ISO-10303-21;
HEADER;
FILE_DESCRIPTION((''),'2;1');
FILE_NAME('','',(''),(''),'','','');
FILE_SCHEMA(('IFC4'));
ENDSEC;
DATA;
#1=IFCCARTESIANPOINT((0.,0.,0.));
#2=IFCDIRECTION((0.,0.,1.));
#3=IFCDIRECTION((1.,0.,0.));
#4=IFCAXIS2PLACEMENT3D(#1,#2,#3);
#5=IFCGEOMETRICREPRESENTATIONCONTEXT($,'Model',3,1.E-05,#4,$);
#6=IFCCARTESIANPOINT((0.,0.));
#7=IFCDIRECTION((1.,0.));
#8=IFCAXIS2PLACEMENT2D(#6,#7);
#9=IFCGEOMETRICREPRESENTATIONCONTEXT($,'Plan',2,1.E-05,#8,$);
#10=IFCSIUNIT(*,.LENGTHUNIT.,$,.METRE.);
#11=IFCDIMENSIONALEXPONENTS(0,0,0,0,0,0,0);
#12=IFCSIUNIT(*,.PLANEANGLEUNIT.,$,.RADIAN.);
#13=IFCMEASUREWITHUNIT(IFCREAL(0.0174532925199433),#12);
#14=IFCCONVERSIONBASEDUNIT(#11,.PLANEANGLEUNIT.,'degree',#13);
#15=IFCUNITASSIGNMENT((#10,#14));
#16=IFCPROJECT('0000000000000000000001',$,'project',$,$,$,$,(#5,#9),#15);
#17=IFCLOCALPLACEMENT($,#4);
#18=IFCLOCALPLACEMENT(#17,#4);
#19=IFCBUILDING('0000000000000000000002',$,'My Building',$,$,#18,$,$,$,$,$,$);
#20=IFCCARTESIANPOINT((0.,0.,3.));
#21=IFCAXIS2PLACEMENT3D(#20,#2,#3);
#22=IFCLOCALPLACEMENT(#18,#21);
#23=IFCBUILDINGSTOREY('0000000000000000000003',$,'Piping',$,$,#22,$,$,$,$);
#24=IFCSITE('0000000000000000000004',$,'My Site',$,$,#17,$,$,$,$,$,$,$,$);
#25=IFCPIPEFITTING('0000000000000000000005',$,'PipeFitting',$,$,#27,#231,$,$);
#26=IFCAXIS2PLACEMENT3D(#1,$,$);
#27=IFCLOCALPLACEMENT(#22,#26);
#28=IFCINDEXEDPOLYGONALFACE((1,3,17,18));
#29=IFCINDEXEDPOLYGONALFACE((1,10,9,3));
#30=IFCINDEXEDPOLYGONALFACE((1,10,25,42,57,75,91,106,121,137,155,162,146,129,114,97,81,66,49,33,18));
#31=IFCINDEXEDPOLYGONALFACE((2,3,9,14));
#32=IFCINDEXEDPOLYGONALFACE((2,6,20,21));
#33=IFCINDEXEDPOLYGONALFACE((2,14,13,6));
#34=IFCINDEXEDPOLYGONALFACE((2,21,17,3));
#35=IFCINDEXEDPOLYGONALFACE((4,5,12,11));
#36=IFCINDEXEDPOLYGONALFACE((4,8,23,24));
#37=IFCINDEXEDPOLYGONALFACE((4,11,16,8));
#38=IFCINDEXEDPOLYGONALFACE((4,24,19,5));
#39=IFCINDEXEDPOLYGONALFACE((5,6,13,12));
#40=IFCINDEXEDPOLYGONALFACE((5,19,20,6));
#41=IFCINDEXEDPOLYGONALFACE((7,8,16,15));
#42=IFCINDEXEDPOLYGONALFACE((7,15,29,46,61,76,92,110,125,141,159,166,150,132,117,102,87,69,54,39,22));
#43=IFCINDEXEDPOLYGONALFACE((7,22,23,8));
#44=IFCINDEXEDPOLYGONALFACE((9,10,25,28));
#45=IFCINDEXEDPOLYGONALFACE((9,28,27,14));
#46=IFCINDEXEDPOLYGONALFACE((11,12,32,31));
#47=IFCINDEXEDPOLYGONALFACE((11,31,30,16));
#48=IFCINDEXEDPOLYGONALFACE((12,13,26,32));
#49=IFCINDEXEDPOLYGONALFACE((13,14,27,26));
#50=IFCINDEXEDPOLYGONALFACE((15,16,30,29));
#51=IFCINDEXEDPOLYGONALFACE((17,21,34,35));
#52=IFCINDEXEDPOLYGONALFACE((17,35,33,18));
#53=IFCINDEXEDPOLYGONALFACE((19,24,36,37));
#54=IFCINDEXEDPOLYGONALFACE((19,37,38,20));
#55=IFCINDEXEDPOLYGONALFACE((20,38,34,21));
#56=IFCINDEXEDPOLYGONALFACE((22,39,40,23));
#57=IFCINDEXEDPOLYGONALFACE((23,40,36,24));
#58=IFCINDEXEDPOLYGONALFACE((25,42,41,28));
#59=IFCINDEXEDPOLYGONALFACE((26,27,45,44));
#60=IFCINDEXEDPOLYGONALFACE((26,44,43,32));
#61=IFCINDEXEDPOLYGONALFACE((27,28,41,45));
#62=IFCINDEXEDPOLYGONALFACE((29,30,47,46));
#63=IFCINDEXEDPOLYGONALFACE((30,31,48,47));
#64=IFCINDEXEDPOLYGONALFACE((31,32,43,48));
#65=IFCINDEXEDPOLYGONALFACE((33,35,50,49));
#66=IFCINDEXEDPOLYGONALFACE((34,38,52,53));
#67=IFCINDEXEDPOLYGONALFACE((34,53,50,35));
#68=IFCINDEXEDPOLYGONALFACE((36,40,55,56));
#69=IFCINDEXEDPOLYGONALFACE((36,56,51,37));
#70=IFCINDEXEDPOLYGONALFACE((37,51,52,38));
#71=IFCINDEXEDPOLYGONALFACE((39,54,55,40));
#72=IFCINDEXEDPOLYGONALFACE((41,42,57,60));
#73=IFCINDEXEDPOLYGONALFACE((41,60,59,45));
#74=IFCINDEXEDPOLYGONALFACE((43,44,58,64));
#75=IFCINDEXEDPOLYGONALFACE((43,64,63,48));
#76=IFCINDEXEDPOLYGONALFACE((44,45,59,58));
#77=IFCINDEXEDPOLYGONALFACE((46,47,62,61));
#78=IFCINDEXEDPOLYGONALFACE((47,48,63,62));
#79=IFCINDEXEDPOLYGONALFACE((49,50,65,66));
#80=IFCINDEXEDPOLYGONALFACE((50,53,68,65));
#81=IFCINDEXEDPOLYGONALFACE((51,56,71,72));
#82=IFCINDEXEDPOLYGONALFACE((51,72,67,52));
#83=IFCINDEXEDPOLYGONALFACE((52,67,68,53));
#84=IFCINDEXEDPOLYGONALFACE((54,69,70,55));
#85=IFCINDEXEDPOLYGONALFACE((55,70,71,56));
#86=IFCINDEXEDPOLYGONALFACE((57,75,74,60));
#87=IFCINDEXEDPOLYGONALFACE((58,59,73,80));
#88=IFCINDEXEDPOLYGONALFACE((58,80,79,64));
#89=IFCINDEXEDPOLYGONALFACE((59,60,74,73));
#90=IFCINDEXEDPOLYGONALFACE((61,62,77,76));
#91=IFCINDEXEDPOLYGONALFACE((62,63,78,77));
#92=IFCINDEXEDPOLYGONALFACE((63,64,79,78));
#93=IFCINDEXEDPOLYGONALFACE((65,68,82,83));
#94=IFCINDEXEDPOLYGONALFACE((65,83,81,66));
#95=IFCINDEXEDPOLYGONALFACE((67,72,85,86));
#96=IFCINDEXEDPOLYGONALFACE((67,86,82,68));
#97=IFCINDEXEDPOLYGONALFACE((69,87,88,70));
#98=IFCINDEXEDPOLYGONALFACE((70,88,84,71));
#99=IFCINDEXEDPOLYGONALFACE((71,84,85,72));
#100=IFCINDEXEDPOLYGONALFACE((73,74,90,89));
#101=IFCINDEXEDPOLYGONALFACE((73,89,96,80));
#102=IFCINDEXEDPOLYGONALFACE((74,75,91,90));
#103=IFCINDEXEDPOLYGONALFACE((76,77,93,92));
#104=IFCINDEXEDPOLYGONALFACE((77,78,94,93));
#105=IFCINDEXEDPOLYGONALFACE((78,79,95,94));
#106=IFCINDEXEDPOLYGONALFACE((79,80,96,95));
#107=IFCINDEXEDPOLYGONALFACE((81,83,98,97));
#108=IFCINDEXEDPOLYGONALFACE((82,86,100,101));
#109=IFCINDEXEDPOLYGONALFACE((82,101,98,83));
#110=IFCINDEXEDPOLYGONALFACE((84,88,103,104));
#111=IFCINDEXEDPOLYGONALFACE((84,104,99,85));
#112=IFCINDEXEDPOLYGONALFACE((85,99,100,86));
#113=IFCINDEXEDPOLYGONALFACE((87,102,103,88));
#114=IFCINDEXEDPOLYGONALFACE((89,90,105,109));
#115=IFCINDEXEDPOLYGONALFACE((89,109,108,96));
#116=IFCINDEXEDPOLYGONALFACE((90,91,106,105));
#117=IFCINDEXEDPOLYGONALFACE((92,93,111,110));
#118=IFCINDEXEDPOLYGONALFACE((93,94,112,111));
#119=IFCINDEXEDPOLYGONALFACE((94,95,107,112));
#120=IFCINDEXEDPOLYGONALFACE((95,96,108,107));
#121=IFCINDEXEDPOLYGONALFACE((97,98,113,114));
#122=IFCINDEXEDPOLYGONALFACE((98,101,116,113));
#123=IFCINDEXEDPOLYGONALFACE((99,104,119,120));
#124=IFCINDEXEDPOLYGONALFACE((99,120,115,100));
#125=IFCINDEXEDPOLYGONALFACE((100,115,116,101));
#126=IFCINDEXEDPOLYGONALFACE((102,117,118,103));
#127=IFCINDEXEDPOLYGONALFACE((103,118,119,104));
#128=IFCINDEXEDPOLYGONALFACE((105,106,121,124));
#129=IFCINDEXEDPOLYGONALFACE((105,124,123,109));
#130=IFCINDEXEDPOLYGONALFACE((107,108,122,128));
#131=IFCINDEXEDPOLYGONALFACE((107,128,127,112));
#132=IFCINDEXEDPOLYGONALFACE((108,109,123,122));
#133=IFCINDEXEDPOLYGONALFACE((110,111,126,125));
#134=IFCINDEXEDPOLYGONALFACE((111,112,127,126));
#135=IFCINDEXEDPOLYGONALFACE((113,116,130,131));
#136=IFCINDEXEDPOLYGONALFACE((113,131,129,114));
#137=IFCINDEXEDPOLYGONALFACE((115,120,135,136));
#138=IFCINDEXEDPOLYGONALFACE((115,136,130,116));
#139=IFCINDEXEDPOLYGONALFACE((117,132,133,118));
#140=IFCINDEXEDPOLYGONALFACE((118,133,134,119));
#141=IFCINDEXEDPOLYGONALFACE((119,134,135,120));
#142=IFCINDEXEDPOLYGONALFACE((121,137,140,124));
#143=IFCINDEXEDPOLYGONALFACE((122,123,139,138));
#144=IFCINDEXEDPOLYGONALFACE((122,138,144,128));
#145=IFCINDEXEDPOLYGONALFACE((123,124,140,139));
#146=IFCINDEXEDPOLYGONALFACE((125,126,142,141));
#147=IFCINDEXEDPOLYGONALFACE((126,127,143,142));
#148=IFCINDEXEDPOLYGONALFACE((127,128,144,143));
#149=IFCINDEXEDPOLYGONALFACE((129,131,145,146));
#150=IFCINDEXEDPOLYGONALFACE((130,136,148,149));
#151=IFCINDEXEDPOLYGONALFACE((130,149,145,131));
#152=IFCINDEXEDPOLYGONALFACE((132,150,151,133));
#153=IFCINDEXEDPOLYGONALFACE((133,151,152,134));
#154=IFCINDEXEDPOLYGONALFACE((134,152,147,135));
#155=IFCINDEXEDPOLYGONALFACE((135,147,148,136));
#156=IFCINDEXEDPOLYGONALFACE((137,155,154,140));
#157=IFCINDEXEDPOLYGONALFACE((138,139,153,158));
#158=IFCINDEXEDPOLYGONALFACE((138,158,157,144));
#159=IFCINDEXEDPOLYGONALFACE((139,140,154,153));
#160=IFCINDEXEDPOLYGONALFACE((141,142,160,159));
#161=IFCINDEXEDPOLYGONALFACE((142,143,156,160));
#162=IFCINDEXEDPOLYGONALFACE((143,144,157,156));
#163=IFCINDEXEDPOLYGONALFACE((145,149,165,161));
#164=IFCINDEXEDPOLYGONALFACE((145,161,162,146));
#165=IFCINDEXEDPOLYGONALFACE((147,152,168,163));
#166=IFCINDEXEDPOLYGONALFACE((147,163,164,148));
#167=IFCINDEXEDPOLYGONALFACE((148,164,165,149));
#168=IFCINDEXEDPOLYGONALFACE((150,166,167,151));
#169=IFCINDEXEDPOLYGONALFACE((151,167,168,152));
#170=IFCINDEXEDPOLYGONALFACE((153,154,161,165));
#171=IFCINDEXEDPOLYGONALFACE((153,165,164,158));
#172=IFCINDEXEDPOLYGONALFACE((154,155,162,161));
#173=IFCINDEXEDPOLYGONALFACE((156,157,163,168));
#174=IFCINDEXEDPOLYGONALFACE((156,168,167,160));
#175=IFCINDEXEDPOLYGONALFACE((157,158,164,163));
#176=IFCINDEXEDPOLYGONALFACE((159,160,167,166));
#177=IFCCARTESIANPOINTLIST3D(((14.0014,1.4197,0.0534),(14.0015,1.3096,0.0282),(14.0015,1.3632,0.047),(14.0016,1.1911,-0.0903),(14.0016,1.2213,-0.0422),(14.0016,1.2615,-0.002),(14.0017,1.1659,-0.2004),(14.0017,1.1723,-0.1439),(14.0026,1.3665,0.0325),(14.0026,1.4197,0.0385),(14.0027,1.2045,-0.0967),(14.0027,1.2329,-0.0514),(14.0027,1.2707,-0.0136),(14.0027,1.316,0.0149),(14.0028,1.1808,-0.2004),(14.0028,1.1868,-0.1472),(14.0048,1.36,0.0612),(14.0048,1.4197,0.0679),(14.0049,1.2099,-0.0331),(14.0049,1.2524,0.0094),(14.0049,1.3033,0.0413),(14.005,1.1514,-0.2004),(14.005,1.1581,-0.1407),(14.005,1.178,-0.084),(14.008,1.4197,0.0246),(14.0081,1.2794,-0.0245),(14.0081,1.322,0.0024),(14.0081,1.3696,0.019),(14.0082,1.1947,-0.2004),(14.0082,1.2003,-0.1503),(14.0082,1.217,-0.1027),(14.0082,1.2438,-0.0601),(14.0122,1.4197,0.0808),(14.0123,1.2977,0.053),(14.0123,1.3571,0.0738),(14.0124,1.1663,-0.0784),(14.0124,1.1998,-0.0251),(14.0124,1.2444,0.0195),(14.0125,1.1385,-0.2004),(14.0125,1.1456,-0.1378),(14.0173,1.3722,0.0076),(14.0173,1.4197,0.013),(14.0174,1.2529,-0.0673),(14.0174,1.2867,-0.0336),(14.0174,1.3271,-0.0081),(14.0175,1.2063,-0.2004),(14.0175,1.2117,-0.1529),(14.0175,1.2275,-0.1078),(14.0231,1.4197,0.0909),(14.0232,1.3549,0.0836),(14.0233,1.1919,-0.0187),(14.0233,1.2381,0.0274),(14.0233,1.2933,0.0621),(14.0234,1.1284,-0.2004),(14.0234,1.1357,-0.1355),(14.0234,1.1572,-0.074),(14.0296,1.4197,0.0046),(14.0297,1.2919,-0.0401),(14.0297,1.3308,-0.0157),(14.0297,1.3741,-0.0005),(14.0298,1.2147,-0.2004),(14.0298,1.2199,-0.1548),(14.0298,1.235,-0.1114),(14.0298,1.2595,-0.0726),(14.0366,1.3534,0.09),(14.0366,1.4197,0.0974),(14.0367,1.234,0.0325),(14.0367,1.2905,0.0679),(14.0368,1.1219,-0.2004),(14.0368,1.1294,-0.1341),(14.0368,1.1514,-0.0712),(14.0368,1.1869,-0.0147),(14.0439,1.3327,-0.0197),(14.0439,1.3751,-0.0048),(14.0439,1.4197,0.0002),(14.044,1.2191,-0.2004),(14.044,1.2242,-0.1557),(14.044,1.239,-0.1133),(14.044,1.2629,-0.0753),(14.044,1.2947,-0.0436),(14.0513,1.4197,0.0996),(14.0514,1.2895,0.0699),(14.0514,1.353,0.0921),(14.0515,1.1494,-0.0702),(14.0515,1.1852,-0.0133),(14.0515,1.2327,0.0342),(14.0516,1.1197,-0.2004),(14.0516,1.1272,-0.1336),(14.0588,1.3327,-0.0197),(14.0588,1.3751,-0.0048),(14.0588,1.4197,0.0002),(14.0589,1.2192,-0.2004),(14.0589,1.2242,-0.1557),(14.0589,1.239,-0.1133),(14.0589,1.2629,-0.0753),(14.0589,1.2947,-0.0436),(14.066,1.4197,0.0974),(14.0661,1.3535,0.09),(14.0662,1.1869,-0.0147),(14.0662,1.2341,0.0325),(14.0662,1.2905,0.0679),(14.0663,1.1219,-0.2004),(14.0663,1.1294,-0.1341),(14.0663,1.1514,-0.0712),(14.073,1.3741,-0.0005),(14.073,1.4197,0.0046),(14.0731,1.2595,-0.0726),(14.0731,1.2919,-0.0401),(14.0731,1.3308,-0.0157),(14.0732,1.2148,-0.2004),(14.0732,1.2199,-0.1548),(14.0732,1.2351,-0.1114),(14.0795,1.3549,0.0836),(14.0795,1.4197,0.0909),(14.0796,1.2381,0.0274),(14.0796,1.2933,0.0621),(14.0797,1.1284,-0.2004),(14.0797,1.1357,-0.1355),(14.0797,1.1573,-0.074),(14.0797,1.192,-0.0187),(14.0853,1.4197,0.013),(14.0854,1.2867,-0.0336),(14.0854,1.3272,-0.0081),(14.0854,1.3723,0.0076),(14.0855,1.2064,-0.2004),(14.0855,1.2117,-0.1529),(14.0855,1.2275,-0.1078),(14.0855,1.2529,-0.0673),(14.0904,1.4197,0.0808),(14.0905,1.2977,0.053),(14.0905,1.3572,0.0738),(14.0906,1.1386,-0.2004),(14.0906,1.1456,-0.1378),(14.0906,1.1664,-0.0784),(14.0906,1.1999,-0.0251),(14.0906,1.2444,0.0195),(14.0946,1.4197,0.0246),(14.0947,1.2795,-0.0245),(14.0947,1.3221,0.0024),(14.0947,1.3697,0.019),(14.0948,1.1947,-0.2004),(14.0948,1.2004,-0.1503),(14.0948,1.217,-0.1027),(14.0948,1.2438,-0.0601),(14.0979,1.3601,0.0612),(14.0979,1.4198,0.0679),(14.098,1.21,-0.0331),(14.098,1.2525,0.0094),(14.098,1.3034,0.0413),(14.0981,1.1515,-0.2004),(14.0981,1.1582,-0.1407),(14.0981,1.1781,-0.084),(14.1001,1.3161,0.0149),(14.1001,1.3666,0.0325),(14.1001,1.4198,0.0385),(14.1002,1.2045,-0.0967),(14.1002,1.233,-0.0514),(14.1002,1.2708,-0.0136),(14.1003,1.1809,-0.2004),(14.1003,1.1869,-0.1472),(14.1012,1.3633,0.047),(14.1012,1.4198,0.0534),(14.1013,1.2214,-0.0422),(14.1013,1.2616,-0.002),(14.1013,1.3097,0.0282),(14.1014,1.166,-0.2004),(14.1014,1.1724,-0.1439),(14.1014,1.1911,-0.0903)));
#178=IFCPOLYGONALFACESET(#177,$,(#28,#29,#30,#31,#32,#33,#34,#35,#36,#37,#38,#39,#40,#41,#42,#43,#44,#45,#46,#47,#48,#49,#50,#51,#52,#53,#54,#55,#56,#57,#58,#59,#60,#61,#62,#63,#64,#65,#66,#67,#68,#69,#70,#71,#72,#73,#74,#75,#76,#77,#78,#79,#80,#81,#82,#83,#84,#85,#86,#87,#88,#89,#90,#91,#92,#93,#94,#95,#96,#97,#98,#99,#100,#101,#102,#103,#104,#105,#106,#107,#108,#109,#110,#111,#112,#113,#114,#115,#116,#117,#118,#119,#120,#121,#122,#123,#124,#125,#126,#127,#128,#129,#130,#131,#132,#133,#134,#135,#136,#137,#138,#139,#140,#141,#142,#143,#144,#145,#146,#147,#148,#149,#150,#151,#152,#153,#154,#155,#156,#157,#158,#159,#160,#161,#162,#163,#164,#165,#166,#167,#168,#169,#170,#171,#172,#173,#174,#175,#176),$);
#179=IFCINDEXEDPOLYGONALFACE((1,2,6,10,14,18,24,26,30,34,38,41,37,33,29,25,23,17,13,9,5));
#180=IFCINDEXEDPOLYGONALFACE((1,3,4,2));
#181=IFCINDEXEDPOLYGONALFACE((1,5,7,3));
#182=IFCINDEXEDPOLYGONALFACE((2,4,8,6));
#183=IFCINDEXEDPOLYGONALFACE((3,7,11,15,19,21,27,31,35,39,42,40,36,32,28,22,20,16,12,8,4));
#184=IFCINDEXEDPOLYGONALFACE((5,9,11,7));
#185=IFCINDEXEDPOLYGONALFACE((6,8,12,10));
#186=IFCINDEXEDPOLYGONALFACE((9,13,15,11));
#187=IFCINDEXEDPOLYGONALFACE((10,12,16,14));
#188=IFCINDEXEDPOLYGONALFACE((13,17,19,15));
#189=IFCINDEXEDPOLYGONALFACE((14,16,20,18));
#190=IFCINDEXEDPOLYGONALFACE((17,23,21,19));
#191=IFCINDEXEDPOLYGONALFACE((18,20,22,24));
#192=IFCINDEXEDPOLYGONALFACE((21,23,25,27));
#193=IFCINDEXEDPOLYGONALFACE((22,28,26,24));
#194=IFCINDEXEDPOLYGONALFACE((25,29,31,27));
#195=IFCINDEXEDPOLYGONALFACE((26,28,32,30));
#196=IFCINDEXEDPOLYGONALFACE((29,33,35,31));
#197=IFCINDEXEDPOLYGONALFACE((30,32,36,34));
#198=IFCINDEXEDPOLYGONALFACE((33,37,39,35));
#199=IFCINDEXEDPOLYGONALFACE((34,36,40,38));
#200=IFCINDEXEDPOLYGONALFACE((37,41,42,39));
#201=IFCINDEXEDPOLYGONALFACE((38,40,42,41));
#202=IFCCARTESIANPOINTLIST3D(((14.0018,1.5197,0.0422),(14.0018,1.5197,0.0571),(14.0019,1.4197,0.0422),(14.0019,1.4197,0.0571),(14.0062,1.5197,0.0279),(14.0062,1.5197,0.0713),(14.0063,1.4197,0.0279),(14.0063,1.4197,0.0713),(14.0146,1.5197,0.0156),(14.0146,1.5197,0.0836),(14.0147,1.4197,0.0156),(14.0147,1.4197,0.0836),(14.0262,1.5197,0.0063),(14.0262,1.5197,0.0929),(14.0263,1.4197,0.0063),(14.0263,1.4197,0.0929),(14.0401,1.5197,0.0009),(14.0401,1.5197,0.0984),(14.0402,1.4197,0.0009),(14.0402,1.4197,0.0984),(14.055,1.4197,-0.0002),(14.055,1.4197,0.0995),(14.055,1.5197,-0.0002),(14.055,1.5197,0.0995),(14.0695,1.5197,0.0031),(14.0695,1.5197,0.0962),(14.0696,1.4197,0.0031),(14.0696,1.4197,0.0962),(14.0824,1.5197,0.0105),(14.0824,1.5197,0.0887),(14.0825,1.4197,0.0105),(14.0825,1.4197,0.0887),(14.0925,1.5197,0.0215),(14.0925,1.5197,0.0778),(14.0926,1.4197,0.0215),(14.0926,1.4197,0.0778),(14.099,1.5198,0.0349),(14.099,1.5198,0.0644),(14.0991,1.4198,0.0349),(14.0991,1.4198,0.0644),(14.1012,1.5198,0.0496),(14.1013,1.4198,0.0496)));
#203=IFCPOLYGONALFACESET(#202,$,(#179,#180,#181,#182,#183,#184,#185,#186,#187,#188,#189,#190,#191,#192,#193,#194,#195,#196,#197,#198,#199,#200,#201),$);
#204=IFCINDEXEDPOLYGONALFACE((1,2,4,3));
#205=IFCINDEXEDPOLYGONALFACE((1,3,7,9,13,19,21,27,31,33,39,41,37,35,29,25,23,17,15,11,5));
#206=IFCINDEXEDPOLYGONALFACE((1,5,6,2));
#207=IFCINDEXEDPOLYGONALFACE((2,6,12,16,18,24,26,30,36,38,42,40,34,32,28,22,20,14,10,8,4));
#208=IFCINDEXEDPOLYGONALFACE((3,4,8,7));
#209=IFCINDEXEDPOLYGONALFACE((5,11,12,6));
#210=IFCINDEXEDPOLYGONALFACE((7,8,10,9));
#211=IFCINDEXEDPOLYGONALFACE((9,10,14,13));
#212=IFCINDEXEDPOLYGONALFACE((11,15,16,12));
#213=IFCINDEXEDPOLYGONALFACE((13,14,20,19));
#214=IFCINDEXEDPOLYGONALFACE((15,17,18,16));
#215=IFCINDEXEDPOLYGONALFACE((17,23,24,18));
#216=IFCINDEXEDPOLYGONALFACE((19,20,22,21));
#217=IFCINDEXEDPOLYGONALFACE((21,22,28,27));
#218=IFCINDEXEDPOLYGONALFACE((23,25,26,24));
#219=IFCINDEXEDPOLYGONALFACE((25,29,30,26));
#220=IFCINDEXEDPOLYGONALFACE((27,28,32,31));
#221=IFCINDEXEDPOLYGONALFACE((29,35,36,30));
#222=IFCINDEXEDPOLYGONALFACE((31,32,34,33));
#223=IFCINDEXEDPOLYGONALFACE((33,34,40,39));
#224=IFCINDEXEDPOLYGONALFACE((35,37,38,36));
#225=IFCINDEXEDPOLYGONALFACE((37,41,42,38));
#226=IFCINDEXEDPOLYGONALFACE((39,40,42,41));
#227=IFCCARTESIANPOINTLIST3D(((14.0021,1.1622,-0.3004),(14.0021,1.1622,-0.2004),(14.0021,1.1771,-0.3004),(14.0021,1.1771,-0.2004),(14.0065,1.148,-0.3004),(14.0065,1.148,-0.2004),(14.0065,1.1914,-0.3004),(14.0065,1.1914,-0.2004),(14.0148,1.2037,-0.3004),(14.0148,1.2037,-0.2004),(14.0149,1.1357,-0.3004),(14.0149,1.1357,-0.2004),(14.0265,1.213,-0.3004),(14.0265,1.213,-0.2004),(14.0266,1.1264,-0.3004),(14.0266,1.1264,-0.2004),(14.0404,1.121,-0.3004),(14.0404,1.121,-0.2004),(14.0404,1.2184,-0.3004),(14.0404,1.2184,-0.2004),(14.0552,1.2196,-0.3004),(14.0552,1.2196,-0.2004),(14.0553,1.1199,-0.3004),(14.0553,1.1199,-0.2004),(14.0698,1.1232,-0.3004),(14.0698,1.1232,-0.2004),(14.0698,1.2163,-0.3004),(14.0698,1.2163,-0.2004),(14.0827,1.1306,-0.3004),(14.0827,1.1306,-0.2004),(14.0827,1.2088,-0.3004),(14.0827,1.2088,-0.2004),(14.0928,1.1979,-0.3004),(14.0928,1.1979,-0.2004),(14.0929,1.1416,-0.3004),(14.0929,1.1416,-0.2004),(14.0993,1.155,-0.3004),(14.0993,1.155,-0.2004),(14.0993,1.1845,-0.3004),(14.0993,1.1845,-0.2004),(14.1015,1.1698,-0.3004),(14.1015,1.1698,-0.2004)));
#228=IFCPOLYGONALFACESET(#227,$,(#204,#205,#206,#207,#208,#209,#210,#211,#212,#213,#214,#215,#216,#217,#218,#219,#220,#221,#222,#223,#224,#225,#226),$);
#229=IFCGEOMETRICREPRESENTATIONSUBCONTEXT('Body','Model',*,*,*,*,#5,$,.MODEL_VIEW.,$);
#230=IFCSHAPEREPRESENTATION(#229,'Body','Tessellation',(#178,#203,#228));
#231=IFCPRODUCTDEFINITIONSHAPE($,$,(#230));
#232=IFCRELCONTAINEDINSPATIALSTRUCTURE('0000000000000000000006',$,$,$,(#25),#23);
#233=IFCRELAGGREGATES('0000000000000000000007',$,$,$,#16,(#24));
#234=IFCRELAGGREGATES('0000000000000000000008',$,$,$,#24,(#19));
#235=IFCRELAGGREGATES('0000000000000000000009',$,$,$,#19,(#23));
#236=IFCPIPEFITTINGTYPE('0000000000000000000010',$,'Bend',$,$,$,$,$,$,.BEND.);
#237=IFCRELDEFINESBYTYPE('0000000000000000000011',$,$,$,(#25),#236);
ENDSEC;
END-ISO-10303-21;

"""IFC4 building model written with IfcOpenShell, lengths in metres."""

from ifc_helpers import new_model, entity, si_unit, converted_unit, frame, origin_with_axes, origin_2d_with_axis, place, context, subcontext, project, spatial, circle, extrude, source, transform, mapped, type_object, type_shapes, element, save


model = new_model("IFC4")

# Units and contexts
model_context = context("Model", 3, precision=1e-05, world=origin_with_axes())
plan_context = context("Plan", 2, precision=1e-05, world=origin_2d_with_axis())
body_context = subcontext(model_context, "Body", "Model", "MODEL_VIEW")
ifc_project = project(units=[si_unit("LENGTHUNIT", "METRE"), converted_unit("PLANEANGLEUNIT", "degree", entity("IfcReal", 0.0174532925199433), si_unit("PLANEANGLEUNIT", "RADIAN"), dimensions=[0, 0, 0, 0, 0, 0, 0])], contexts=[model_context, plan_context])

# Site, building, storey
site_placement = place(None, origin_with_axes())
site = spatial("IfcSite", under=ifc_project, at=site_placement, Name="My Site")
building_placement = place(site_placement, origin_with_axes())
building = spatial("IfcBuilding", under=site, at=building_placement, Name="My Building")
storey_placement = place(building_placement, frame((0.0, 0.0, 3.0), z_axis=(0.0, 0.0, 1.0), x_axis=(1.0, 0.0, 0.0)))
storey = spatial("IfcBuildingStorey", under=building, at=storey_placement, Name="Piping")

# Pipe fitting
pipe_fitting_type_1 = type_object("IfcPipeFittingType", Name="Bend", PredefinedType="BEND")
shared_shape = source(origin_with_axes(), body_context, "Body", "SolidModel", [
    entity("IfcSweptDiskSolid", entity("IfcIndexedPolyCurve", entity("IfcCartesianPointList3D", [[0.0, 0.0, 0.1], [0.0, -0.0732, 0.2768], [0.0, -0.25, 0.35]]), [entity("IfcArcIndex", [1, 2, 3])]), 0.05),
    extrude(circle(Radius=0.05), origin_with_axes(), (0.0, 0.0, 1.0), 0.1),
    extrude(circle(Radius=0.05), frame((0.0, -0.25, 0.35), z_axis=(0.0, -1.0, -0.000001), x_axis=(1.0, 0.0, 0.0)), (0.0, 0.0, 1.0), 0.1),
])
type_shapes(pipe_fitting_type_1, [shared_shape])
for number, where, z_axis, x_axis, name in (
    (1, (14.0512, 1.5197, 0.0496), (0.000872, -1.0, 0.000001), (1.0, 0.000872, 0.0), "PipeFitting"),
):
    element("IfcPipeFitting", number, at=place(storey_placement, frame(where, z_axis=z_axis, x_axis=x_axis)), inside=storey, type_object=pipe_fitting_type_1, Name=name, context=body_context, shape_type="MappedRepresentation", body=[
        mapped(shared_shape, transform((0.0, 0.0, 0.0), x_axis=(1.0, 0.0, 0.0), y_axis=(0.0, 1.0, 0.0), z_axis=(0.0, 0.0, 1.0), scale=1.0)),
    ])

save(model, "model.ifc")
